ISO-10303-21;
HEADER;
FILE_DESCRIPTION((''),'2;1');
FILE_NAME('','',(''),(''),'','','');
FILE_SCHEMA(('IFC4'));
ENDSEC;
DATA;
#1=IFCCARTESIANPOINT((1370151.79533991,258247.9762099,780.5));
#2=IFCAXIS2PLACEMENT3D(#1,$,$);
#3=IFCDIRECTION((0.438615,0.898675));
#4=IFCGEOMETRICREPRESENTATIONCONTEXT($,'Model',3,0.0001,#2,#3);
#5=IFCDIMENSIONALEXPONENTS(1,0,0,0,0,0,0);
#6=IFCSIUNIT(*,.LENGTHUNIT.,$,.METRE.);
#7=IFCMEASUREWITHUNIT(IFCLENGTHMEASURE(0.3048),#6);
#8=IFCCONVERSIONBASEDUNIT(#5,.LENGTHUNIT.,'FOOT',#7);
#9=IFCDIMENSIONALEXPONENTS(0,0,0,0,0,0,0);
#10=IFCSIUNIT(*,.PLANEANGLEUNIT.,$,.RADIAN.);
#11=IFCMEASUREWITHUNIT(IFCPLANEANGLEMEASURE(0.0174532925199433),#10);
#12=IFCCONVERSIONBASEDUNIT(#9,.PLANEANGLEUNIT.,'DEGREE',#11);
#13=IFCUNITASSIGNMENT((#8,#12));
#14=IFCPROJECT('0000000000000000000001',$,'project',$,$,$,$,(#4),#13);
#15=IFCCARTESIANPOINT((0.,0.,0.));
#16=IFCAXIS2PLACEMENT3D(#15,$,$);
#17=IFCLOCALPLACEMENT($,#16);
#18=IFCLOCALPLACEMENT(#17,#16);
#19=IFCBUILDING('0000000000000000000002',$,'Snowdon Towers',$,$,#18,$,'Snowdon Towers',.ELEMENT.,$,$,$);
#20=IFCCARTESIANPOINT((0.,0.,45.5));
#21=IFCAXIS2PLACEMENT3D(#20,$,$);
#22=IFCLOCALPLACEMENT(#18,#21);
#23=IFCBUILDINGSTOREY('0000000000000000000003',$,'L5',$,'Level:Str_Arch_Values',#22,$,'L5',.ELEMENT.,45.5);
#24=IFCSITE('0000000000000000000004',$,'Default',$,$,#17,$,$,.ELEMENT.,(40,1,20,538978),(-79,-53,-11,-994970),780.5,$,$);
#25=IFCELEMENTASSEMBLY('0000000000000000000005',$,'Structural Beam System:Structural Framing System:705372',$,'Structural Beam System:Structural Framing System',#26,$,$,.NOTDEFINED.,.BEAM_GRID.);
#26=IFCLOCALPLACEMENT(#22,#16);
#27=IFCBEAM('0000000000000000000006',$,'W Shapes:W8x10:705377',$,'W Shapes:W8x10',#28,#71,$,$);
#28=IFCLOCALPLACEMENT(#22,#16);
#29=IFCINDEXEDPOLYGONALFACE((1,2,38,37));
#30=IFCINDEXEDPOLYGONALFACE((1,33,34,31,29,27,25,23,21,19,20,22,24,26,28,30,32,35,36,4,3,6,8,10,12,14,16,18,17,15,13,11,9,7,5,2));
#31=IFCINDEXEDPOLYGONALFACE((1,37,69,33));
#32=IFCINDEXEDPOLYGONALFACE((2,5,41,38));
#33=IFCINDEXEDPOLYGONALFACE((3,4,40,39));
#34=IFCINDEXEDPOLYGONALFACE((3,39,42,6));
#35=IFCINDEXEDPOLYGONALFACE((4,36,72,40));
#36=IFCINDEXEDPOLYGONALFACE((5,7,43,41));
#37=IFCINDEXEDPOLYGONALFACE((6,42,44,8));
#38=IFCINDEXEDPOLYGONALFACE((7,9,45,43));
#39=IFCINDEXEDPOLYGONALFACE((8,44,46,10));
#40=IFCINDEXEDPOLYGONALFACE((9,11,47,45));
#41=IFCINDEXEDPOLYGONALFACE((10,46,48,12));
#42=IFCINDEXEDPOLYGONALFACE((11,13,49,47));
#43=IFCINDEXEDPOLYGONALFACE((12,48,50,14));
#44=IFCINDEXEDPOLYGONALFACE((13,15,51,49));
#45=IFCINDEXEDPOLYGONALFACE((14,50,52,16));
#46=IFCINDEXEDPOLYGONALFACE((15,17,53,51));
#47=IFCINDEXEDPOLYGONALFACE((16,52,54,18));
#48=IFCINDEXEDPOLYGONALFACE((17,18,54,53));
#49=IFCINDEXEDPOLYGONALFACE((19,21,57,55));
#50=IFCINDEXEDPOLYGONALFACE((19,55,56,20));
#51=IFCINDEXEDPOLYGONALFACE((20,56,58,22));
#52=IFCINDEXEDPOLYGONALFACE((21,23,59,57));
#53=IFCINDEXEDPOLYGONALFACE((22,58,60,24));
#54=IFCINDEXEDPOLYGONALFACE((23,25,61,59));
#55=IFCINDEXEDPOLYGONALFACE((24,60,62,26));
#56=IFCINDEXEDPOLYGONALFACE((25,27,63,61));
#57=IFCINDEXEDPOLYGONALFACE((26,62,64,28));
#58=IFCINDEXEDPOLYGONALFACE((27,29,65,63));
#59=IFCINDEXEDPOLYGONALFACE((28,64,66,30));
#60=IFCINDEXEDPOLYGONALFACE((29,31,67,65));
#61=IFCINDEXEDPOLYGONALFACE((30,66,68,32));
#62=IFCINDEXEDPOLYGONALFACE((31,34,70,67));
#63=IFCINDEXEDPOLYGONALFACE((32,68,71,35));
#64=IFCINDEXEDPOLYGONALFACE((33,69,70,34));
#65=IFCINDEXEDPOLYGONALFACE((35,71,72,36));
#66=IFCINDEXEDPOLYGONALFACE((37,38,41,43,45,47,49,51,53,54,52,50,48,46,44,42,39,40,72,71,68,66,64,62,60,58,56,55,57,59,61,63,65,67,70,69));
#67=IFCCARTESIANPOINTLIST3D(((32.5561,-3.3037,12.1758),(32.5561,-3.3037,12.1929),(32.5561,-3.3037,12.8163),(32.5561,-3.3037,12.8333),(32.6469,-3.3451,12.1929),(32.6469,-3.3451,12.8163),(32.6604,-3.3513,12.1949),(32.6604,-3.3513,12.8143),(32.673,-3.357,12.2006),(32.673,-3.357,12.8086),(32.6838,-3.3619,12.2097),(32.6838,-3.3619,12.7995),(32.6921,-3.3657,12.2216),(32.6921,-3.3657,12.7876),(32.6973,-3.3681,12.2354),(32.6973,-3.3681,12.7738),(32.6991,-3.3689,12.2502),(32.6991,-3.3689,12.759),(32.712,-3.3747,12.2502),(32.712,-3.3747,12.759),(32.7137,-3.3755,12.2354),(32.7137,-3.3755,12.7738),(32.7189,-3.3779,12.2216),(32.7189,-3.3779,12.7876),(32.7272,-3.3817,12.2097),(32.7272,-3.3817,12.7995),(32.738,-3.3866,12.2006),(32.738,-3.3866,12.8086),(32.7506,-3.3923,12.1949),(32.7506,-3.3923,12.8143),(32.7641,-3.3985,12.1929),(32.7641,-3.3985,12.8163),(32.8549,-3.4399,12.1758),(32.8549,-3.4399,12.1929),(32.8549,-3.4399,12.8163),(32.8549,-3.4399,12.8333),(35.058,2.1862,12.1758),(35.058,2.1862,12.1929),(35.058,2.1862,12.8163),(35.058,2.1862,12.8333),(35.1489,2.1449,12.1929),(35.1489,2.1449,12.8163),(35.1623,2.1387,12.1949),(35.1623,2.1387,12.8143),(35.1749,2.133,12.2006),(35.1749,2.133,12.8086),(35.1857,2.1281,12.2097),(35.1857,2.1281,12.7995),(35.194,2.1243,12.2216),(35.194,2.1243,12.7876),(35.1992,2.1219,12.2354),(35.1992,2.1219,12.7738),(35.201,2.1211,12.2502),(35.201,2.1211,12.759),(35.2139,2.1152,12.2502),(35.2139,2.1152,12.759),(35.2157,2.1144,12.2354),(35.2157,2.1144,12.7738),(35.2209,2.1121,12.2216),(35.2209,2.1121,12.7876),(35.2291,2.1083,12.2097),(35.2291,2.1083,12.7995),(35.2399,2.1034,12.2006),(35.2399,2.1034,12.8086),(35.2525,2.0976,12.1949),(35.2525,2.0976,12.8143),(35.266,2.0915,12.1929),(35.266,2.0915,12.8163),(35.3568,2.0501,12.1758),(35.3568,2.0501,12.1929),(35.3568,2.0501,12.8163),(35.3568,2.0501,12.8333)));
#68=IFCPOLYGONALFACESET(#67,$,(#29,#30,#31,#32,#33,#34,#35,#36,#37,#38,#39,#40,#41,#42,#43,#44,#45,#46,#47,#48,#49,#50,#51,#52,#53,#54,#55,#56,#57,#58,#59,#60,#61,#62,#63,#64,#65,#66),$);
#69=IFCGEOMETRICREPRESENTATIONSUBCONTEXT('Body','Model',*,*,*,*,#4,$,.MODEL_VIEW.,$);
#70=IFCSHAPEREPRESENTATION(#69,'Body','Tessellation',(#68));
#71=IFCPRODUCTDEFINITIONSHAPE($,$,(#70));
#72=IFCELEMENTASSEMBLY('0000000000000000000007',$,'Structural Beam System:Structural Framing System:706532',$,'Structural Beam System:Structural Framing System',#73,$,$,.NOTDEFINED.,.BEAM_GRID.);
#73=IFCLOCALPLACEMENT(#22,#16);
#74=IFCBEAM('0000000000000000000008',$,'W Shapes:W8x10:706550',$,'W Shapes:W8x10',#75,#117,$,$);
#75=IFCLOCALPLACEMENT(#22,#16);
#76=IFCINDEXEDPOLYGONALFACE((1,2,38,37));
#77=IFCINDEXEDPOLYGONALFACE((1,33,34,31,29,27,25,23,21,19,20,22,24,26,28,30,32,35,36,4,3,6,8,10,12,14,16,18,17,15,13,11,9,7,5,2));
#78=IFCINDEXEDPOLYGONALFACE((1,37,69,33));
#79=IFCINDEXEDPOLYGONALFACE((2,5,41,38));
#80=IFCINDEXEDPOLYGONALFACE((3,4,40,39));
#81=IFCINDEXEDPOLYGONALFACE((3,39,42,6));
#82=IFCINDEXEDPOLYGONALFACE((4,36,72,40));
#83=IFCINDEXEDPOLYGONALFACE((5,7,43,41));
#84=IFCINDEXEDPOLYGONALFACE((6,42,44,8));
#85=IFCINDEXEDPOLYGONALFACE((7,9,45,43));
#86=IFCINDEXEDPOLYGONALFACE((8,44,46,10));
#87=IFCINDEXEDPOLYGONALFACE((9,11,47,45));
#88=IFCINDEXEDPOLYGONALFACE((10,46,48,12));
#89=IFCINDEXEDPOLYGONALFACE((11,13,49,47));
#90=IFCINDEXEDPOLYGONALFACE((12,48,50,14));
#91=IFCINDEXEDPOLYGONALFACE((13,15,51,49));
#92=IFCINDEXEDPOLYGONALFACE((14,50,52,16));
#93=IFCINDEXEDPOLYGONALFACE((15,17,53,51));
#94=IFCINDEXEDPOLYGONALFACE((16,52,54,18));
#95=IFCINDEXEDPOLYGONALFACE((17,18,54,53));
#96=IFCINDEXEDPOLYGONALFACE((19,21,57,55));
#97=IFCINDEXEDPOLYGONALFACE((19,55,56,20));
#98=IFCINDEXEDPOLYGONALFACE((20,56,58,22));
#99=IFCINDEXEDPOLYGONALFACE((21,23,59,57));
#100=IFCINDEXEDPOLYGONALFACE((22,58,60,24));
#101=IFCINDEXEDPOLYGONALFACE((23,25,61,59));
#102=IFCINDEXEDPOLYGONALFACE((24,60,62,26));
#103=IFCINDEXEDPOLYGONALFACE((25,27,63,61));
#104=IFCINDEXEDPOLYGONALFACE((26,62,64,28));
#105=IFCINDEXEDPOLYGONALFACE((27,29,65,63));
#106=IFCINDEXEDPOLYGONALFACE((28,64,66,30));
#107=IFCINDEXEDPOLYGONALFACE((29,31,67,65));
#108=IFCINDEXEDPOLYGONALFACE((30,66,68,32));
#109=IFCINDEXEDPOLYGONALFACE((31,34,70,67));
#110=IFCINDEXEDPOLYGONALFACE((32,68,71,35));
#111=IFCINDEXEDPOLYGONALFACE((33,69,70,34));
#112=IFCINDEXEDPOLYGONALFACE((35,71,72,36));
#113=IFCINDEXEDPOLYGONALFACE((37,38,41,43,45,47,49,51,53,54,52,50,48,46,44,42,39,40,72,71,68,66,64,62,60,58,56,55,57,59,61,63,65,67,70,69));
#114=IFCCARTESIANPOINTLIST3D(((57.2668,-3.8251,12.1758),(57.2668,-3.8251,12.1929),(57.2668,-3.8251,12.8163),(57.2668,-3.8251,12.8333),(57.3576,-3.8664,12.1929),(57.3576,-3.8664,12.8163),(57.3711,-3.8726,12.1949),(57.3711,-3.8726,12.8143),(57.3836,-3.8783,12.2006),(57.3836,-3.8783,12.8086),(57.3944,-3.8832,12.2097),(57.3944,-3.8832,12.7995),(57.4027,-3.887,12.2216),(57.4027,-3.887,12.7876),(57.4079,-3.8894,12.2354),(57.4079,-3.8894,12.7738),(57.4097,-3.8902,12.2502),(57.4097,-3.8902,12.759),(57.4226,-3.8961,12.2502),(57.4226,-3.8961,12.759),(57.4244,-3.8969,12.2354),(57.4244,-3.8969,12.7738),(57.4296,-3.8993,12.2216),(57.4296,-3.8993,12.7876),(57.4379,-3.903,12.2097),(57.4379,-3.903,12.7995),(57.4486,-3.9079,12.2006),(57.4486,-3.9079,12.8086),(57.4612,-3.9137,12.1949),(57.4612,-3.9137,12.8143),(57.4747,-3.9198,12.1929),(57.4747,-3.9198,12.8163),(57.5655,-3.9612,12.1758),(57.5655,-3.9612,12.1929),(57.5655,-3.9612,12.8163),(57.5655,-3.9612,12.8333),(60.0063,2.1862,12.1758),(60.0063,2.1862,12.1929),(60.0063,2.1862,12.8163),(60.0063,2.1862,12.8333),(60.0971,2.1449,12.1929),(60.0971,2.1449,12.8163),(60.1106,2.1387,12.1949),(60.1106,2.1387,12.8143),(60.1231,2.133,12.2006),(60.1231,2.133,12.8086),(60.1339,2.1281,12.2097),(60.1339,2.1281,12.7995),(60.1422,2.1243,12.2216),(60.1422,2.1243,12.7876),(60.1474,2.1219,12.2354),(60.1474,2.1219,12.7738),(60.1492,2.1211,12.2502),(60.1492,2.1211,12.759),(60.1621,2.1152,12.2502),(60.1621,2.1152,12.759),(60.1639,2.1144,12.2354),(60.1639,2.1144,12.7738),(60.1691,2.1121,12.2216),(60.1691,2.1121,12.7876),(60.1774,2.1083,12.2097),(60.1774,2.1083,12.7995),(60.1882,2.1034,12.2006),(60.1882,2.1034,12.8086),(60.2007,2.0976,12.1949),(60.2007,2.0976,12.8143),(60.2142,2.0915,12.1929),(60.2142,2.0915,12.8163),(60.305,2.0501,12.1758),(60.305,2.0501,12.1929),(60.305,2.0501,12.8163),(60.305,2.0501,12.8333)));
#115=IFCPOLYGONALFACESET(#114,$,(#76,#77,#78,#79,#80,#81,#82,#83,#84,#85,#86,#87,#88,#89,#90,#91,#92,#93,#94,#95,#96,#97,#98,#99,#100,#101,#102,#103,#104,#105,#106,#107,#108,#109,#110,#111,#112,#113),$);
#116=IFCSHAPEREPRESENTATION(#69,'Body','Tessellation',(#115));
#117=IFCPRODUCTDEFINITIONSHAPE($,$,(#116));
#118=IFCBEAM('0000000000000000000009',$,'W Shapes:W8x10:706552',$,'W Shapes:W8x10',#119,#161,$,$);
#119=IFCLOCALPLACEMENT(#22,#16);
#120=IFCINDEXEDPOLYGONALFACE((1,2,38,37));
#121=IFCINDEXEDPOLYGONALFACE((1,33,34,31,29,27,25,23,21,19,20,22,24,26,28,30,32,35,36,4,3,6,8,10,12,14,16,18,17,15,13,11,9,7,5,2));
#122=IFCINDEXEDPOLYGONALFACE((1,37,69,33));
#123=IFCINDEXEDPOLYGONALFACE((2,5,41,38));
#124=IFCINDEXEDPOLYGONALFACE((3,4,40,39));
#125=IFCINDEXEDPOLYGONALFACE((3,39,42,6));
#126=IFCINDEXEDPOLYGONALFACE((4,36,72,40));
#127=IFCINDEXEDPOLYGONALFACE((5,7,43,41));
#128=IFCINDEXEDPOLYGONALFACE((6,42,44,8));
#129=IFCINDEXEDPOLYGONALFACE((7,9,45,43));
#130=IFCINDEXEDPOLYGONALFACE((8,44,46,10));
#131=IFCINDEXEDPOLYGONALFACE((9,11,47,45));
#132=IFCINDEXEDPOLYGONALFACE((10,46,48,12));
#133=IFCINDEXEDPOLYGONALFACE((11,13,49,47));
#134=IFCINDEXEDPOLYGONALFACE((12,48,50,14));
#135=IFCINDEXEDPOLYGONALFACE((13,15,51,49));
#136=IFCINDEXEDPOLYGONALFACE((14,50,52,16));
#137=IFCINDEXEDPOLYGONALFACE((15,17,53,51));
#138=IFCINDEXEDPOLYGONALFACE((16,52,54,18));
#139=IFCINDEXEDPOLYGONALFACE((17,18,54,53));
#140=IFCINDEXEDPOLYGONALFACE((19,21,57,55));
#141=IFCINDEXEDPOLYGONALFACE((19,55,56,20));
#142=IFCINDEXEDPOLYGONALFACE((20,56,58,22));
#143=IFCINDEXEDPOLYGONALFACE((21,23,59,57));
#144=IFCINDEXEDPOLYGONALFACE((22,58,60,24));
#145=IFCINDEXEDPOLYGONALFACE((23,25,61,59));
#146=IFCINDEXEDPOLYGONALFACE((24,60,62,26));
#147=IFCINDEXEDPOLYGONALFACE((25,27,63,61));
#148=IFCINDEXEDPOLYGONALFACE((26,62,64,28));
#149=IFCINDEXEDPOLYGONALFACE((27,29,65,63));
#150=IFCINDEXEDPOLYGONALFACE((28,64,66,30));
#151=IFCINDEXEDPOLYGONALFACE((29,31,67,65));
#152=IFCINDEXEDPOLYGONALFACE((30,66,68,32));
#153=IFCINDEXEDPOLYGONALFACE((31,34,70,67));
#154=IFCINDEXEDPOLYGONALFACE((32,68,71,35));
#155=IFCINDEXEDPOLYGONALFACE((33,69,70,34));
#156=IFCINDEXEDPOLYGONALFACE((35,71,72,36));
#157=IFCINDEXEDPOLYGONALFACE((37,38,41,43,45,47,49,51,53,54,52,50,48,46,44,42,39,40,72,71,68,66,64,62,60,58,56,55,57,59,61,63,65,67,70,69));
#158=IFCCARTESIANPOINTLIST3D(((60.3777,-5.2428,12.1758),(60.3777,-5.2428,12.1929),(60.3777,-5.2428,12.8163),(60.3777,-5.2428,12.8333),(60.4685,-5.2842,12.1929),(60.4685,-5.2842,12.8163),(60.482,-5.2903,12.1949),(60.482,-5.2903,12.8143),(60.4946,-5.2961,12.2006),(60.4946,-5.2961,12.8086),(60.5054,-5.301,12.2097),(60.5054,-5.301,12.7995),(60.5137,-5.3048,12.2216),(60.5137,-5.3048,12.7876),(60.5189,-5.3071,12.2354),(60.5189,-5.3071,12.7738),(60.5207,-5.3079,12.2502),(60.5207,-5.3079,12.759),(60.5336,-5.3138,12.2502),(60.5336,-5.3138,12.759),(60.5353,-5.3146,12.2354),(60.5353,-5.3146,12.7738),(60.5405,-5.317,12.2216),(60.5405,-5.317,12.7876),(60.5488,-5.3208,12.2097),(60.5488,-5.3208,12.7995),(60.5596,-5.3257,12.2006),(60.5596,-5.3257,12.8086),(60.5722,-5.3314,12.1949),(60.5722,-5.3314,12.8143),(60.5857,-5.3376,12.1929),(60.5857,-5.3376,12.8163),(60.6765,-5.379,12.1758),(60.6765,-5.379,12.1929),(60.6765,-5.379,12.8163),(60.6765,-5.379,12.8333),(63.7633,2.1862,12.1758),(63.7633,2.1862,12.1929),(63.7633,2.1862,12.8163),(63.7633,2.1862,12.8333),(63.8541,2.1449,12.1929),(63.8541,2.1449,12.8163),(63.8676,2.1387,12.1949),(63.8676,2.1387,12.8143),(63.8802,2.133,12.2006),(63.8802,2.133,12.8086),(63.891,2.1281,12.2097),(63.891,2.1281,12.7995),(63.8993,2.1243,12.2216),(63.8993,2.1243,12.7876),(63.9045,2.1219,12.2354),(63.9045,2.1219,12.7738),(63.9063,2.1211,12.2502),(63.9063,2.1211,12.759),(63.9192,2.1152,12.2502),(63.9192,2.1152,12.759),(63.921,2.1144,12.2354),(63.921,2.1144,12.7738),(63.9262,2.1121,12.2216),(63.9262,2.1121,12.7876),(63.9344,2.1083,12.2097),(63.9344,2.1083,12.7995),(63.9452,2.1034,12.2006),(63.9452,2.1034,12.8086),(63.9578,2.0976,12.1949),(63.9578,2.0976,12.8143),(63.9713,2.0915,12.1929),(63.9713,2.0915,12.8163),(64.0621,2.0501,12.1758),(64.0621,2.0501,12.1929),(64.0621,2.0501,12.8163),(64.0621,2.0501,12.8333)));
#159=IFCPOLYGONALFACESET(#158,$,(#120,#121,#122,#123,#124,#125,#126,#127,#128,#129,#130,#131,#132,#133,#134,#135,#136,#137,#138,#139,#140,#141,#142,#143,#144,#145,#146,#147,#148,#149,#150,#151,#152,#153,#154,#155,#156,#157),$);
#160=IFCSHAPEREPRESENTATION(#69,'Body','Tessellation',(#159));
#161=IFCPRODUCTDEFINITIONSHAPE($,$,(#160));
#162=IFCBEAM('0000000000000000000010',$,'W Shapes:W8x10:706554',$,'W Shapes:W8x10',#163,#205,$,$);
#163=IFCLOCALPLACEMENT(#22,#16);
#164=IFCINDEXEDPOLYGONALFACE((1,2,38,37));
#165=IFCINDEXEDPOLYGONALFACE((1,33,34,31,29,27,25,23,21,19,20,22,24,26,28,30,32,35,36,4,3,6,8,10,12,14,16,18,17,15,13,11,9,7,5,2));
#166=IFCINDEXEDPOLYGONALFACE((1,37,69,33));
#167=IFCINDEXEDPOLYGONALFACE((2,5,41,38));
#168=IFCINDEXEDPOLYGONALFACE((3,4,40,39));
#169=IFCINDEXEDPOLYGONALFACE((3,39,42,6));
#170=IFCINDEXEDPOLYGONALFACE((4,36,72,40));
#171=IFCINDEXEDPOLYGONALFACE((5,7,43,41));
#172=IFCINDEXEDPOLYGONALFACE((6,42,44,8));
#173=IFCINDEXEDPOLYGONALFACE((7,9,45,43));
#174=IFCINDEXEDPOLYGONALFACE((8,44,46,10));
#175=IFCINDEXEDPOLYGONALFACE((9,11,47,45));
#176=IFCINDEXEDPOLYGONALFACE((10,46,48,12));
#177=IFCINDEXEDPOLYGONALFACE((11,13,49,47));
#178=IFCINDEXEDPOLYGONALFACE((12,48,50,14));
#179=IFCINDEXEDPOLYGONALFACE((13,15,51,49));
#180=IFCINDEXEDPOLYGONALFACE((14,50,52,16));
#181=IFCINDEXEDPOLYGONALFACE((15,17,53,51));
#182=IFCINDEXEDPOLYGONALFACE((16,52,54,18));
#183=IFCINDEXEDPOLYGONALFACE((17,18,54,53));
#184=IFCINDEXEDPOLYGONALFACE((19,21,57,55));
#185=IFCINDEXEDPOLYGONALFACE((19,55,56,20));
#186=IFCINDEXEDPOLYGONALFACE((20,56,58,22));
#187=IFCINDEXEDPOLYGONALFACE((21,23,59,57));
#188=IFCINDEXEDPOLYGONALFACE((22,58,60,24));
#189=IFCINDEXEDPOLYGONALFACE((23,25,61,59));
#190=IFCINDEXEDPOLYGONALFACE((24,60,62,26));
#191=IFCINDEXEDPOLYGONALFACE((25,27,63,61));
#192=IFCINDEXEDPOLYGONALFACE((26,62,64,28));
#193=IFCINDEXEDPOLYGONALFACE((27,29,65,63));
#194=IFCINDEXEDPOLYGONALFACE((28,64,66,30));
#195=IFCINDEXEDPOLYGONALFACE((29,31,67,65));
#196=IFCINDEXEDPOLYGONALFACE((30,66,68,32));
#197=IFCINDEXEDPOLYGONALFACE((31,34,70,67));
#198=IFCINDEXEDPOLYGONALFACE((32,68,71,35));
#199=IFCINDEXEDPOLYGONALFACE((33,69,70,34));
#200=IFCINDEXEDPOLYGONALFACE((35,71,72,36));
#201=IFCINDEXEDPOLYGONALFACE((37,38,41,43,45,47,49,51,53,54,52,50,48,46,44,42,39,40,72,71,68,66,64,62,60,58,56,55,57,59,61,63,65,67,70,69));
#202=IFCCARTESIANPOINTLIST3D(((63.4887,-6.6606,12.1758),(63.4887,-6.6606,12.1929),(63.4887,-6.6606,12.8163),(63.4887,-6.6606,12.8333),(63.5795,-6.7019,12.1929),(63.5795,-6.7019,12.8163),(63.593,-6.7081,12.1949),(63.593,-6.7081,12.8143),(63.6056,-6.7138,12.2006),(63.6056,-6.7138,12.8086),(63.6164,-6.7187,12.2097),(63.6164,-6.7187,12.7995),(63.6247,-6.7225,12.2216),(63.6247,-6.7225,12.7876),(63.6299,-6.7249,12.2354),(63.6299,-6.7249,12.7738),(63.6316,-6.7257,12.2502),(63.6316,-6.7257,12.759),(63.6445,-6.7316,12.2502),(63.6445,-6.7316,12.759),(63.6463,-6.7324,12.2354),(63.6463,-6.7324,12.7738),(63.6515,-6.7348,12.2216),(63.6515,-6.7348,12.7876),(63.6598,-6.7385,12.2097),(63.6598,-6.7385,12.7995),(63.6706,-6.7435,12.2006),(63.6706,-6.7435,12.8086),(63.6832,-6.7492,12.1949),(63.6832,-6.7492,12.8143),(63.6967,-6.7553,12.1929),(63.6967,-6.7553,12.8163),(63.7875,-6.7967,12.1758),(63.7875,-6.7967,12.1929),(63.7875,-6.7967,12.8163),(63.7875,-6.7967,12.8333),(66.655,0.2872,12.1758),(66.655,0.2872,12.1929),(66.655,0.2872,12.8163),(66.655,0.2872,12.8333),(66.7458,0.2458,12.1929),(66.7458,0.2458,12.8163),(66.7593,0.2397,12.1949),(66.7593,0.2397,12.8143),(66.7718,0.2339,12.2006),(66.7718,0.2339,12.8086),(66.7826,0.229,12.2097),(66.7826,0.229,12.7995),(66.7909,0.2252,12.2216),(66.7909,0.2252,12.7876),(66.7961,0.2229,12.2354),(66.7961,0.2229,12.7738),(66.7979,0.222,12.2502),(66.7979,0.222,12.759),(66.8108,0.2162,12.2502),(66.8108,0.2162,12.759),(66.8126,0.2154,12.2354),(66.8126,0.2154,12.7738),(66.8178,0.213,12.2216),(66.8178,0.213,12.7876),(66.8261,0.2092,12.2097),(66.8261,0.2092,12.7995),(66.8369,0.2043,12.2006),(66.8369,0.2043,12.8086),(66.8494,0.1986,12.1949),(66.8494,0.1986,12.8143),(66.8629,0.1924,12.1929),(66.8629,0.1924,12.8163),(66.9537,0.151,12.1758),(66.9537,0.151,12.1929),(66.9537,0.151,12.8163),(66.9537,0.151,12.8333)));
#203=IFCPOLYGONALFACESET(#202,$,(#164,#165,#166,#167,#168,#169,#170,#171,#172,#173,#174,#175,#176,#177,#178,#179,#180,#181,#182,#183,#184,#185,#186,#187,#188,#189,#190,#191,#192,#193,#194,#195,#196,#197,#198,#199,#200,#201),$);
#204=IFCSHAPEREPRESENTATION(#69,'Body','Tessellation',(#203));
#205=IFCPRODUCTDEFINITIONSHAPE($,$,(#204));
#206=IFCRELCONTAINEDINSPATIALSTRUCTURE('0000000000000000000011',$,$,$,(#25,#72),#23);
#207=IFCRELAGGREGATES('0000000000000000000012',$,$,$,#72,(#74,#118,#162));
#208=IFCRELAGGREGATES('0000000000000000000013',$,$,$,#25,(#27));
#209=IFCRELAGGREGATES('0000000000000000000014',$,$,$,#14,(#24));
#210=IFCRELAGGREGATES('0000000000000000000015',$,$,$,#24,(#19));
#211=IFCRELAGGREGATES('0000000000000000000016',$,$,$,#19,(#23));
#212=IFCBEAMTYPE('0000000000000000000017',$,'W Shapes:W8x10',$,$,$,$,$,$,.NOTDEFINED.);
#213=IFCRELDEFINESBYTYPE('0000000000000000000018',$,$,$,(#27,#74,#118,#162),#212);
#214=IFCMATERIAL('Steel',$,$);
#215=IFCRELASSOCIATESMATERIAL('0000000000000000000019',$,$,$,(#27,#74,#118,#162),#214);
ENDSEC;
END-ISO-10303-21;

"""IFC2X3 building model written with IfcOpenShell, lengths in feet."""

from ifc_helpers import new_model, entity, si_unit, converted_unit, direction, frame, frame_2d, origin, place, context, subcontext, project, spatial, i_section, extrude, material, type_object, element, aggregate, save


model = new_model("IFC2X3")

# Units and contexts
model_context = context("Model", 3, precision=0.0001, world=frame((1370151.79533991, 258247.9762099, 780.5)), true_north=direction((0.438615, 0.898675)))
body_context = subcontext(model_context, "Body", "Model", "MODEL_VIEW")
ifc_project = project(units=[converted_unit("LENGTHUNIT", "FOOT", entity("IfcLengthMeasure", 0.3048), si_unit("LENGTHUNIT", "METRE"), dimensions=[1, 0, 0, 0, 0, 0, 0]), converted_unit("PLANEANGLEUNIT", "DEGREE", entity("IfcPlaneAngleMeasure", 0.0174532925199433), si_unit("PLANEANGLEUNIT", "RADIAN"), dimensions=[0, 0, 0, 0, 0, 0, 0])], contexts=[model_context])

# Site, building, storey
site_placement = place(None, origin())
site = spatial("IfcSite", under=ifc_project, at=site_placement, Name="Default", CompositionType="ELEMENT", RefLatitude=(40, 1, 20, 538978), RefLongitude=(-79, -53, -11, -994970), RefElevation=780.5)
building_placement = place(site_placement, origin())
building = spatial("IfcBuilding", under=site, at=building_placement, Name="Snowdon Towers", LongName="Snowdon Towers", CompositionType="ELEMENT")
storey_placement = place(building_placement, frame((0.0, 0.0, 45.5)))
storey = spatial("IfcBuildingStorey", under=building, at=storey_placement, Name="L5", ObjectType="Level:Str_Arch_Values", LongName="L5", CompositionType="ELEMENT", Elevation=45.5)

# Shared definitions
ifc_material = material(Name="Steel")

# Shared definitions
beam_type_1 = type_object("IfcBeamType", Name="W Shapes:W8x10", PredefinedType="NOTDEFINED")

# Element assemblies, beams
assembly_1_placement = place(storey_placement, origin())
assembly_1 = element("IfcElementAssembly", 1, at=assembly_1_placement, inside=storey, Name="Structural Beam System:Structural Framing System:705372", ObjectType="Structural Beam System:Structural Framing System", AssemblyPlace="NOTDEFINED", PredefinedType="BEAM_GRID")
beam_1_placement = place(assembly_1_placement, frame((32.5934, -3.6179, 12.8333), z_axis=(0.0, 0.0, 1.0), x_axis=(0.414693, 0.909961, 0.0)))
beam_1 = element("IfcBeam", 2, at=beam_1_placement, type_object=beam_type_1, material=ifc_material, Name="W Shapes:W8x10:705377", ObjectType="W Shapes:W8x10", context=body_context, shape_type="SweptSolid", body=[
    extrude(i_section(OverallWidth=0.3283, OverallDepth=0.6575, WebThickness=0.0142, FlangeThickness=0.0171, FilletRadius=0.0573, at=frame_2d((0.0, 0.0), x_axis=(0.0, 1.0))), frame((0.2704, 0.0, -0.3288), z_axis=(1.0, 0.0, 0.0), x_axis=(0.0, 0.0, -1.0)), (0.0, 0.0, 1.0), 6.0332),
])
assembly_2_placement = place(storey_placement, origin())
assembly_2 = element("IfcElementAssembly", 3, at=assembly_2_placement, inside=storey, Name="Structural Beam System:Structural Framing System:706532", ObjectType="Structural Beam System:Structural Framing System", AssemblyPlace="NOTDEFINED", PredefinedType="BEAM_GRID")
beam_2_placement = place(assembly_2_placement, frame((57.304, -4.1392, 12.8333), z_axis=(0.0, 0.0, 1.0), x_axis=(0.414693, 0.909961, 0.0)))
beam_2 = element("IfcBeam", 4, at=beam_2_placement, type_object=beam_type_1, material=ifc_material, Name="W Shapes:W8x10:706550", ObjectType="W Shapes:W8x10", context=body_context, shape_type="SweptSolid", body=[
    extrude(i_section(OverallWidth=0.3283, OverallDepth=0.6575, WebThickness=0.0142, FlangeThickness=0.0171, FilletRadius=0.0573, at=frame_2d((0.0, 0.0), x_axis=(0.0, 1.0))), frame((0.2704, 0.0, -0.3288), z_axis=(1.0, 0.0, 0.0), x_axis=(0.0, 0.0, -1.0)), (0.0, 0.0, 1.0), 6.6061),
])
beam_3_placement = place(assembly_2_placement, frame((60.415, -5.557, 12.8333), z_axis=(0.0, 0.0, 1.0), x_axis=(0.414693, 0.909961, 0.0)))
beam_3 = element("IfcBeam", 5, at=beam_3_placement, type_object=beam_type_1, material=ifc_material, Name="W Shapes:W8x10:706552", ObjectType="W Shapes:W8x10", context=body_context, shape_type="SweptSolid", body=[
    extrude(i_section(OverallWidth=0.3283, OverallDepth=0.6575, WebThickness=0.0142, FlangeThickness=0.0171, FilletRadius=0.0573, at=frame_2d((0.0, 0.0), x_axis=(0.0, 1.0))), frame((0.2704, 0.0, -0.3288), z_axis=(1.0, 0.0, 0.0), x_axis=(0.0, 0.0, -1.0)), (0.0, 0.0, 1.0), 8.1641),
])
beam_4_placement = place(assembly_2_placement, frame((63.5259, -6.9747, 12.8333), z_axis=(0.0, 0.0, 1.0), x_axis=(0.414693, 0.909961, 0.0)))
beam_4 = element("IfcBeam", 6, at=beam_4_placement, type_object=beam_type_1, material=ifc_material, Name="W Shapes:W8x10:706554", ObjectType="W Shapes:W8x10", context=body_context, shape_type="SweptSolid", body=[
    extrude(i_section(OverallWidth=0.3283, OverallDepth=0.6575, WebThickness=0.0142, FlangeThickness=0.0171, FilletRadius=0.0573, at=frame_2d((0.0, 0.0), x_axis=(0.0, 1.0))), frame((0.2704, 0.0, -0.3288), z_axis=(1.0, 0.0, 0.0), x_axis=(0.0, 0.0, -1.0)), (0.0, 0.0, 1.0), 7.6352),
])
aggregate(assembly_2, [beam_2, beam_3, beam_4])

aggregate(assembly_1, [beam_1])

save(model, "model.ifc")
